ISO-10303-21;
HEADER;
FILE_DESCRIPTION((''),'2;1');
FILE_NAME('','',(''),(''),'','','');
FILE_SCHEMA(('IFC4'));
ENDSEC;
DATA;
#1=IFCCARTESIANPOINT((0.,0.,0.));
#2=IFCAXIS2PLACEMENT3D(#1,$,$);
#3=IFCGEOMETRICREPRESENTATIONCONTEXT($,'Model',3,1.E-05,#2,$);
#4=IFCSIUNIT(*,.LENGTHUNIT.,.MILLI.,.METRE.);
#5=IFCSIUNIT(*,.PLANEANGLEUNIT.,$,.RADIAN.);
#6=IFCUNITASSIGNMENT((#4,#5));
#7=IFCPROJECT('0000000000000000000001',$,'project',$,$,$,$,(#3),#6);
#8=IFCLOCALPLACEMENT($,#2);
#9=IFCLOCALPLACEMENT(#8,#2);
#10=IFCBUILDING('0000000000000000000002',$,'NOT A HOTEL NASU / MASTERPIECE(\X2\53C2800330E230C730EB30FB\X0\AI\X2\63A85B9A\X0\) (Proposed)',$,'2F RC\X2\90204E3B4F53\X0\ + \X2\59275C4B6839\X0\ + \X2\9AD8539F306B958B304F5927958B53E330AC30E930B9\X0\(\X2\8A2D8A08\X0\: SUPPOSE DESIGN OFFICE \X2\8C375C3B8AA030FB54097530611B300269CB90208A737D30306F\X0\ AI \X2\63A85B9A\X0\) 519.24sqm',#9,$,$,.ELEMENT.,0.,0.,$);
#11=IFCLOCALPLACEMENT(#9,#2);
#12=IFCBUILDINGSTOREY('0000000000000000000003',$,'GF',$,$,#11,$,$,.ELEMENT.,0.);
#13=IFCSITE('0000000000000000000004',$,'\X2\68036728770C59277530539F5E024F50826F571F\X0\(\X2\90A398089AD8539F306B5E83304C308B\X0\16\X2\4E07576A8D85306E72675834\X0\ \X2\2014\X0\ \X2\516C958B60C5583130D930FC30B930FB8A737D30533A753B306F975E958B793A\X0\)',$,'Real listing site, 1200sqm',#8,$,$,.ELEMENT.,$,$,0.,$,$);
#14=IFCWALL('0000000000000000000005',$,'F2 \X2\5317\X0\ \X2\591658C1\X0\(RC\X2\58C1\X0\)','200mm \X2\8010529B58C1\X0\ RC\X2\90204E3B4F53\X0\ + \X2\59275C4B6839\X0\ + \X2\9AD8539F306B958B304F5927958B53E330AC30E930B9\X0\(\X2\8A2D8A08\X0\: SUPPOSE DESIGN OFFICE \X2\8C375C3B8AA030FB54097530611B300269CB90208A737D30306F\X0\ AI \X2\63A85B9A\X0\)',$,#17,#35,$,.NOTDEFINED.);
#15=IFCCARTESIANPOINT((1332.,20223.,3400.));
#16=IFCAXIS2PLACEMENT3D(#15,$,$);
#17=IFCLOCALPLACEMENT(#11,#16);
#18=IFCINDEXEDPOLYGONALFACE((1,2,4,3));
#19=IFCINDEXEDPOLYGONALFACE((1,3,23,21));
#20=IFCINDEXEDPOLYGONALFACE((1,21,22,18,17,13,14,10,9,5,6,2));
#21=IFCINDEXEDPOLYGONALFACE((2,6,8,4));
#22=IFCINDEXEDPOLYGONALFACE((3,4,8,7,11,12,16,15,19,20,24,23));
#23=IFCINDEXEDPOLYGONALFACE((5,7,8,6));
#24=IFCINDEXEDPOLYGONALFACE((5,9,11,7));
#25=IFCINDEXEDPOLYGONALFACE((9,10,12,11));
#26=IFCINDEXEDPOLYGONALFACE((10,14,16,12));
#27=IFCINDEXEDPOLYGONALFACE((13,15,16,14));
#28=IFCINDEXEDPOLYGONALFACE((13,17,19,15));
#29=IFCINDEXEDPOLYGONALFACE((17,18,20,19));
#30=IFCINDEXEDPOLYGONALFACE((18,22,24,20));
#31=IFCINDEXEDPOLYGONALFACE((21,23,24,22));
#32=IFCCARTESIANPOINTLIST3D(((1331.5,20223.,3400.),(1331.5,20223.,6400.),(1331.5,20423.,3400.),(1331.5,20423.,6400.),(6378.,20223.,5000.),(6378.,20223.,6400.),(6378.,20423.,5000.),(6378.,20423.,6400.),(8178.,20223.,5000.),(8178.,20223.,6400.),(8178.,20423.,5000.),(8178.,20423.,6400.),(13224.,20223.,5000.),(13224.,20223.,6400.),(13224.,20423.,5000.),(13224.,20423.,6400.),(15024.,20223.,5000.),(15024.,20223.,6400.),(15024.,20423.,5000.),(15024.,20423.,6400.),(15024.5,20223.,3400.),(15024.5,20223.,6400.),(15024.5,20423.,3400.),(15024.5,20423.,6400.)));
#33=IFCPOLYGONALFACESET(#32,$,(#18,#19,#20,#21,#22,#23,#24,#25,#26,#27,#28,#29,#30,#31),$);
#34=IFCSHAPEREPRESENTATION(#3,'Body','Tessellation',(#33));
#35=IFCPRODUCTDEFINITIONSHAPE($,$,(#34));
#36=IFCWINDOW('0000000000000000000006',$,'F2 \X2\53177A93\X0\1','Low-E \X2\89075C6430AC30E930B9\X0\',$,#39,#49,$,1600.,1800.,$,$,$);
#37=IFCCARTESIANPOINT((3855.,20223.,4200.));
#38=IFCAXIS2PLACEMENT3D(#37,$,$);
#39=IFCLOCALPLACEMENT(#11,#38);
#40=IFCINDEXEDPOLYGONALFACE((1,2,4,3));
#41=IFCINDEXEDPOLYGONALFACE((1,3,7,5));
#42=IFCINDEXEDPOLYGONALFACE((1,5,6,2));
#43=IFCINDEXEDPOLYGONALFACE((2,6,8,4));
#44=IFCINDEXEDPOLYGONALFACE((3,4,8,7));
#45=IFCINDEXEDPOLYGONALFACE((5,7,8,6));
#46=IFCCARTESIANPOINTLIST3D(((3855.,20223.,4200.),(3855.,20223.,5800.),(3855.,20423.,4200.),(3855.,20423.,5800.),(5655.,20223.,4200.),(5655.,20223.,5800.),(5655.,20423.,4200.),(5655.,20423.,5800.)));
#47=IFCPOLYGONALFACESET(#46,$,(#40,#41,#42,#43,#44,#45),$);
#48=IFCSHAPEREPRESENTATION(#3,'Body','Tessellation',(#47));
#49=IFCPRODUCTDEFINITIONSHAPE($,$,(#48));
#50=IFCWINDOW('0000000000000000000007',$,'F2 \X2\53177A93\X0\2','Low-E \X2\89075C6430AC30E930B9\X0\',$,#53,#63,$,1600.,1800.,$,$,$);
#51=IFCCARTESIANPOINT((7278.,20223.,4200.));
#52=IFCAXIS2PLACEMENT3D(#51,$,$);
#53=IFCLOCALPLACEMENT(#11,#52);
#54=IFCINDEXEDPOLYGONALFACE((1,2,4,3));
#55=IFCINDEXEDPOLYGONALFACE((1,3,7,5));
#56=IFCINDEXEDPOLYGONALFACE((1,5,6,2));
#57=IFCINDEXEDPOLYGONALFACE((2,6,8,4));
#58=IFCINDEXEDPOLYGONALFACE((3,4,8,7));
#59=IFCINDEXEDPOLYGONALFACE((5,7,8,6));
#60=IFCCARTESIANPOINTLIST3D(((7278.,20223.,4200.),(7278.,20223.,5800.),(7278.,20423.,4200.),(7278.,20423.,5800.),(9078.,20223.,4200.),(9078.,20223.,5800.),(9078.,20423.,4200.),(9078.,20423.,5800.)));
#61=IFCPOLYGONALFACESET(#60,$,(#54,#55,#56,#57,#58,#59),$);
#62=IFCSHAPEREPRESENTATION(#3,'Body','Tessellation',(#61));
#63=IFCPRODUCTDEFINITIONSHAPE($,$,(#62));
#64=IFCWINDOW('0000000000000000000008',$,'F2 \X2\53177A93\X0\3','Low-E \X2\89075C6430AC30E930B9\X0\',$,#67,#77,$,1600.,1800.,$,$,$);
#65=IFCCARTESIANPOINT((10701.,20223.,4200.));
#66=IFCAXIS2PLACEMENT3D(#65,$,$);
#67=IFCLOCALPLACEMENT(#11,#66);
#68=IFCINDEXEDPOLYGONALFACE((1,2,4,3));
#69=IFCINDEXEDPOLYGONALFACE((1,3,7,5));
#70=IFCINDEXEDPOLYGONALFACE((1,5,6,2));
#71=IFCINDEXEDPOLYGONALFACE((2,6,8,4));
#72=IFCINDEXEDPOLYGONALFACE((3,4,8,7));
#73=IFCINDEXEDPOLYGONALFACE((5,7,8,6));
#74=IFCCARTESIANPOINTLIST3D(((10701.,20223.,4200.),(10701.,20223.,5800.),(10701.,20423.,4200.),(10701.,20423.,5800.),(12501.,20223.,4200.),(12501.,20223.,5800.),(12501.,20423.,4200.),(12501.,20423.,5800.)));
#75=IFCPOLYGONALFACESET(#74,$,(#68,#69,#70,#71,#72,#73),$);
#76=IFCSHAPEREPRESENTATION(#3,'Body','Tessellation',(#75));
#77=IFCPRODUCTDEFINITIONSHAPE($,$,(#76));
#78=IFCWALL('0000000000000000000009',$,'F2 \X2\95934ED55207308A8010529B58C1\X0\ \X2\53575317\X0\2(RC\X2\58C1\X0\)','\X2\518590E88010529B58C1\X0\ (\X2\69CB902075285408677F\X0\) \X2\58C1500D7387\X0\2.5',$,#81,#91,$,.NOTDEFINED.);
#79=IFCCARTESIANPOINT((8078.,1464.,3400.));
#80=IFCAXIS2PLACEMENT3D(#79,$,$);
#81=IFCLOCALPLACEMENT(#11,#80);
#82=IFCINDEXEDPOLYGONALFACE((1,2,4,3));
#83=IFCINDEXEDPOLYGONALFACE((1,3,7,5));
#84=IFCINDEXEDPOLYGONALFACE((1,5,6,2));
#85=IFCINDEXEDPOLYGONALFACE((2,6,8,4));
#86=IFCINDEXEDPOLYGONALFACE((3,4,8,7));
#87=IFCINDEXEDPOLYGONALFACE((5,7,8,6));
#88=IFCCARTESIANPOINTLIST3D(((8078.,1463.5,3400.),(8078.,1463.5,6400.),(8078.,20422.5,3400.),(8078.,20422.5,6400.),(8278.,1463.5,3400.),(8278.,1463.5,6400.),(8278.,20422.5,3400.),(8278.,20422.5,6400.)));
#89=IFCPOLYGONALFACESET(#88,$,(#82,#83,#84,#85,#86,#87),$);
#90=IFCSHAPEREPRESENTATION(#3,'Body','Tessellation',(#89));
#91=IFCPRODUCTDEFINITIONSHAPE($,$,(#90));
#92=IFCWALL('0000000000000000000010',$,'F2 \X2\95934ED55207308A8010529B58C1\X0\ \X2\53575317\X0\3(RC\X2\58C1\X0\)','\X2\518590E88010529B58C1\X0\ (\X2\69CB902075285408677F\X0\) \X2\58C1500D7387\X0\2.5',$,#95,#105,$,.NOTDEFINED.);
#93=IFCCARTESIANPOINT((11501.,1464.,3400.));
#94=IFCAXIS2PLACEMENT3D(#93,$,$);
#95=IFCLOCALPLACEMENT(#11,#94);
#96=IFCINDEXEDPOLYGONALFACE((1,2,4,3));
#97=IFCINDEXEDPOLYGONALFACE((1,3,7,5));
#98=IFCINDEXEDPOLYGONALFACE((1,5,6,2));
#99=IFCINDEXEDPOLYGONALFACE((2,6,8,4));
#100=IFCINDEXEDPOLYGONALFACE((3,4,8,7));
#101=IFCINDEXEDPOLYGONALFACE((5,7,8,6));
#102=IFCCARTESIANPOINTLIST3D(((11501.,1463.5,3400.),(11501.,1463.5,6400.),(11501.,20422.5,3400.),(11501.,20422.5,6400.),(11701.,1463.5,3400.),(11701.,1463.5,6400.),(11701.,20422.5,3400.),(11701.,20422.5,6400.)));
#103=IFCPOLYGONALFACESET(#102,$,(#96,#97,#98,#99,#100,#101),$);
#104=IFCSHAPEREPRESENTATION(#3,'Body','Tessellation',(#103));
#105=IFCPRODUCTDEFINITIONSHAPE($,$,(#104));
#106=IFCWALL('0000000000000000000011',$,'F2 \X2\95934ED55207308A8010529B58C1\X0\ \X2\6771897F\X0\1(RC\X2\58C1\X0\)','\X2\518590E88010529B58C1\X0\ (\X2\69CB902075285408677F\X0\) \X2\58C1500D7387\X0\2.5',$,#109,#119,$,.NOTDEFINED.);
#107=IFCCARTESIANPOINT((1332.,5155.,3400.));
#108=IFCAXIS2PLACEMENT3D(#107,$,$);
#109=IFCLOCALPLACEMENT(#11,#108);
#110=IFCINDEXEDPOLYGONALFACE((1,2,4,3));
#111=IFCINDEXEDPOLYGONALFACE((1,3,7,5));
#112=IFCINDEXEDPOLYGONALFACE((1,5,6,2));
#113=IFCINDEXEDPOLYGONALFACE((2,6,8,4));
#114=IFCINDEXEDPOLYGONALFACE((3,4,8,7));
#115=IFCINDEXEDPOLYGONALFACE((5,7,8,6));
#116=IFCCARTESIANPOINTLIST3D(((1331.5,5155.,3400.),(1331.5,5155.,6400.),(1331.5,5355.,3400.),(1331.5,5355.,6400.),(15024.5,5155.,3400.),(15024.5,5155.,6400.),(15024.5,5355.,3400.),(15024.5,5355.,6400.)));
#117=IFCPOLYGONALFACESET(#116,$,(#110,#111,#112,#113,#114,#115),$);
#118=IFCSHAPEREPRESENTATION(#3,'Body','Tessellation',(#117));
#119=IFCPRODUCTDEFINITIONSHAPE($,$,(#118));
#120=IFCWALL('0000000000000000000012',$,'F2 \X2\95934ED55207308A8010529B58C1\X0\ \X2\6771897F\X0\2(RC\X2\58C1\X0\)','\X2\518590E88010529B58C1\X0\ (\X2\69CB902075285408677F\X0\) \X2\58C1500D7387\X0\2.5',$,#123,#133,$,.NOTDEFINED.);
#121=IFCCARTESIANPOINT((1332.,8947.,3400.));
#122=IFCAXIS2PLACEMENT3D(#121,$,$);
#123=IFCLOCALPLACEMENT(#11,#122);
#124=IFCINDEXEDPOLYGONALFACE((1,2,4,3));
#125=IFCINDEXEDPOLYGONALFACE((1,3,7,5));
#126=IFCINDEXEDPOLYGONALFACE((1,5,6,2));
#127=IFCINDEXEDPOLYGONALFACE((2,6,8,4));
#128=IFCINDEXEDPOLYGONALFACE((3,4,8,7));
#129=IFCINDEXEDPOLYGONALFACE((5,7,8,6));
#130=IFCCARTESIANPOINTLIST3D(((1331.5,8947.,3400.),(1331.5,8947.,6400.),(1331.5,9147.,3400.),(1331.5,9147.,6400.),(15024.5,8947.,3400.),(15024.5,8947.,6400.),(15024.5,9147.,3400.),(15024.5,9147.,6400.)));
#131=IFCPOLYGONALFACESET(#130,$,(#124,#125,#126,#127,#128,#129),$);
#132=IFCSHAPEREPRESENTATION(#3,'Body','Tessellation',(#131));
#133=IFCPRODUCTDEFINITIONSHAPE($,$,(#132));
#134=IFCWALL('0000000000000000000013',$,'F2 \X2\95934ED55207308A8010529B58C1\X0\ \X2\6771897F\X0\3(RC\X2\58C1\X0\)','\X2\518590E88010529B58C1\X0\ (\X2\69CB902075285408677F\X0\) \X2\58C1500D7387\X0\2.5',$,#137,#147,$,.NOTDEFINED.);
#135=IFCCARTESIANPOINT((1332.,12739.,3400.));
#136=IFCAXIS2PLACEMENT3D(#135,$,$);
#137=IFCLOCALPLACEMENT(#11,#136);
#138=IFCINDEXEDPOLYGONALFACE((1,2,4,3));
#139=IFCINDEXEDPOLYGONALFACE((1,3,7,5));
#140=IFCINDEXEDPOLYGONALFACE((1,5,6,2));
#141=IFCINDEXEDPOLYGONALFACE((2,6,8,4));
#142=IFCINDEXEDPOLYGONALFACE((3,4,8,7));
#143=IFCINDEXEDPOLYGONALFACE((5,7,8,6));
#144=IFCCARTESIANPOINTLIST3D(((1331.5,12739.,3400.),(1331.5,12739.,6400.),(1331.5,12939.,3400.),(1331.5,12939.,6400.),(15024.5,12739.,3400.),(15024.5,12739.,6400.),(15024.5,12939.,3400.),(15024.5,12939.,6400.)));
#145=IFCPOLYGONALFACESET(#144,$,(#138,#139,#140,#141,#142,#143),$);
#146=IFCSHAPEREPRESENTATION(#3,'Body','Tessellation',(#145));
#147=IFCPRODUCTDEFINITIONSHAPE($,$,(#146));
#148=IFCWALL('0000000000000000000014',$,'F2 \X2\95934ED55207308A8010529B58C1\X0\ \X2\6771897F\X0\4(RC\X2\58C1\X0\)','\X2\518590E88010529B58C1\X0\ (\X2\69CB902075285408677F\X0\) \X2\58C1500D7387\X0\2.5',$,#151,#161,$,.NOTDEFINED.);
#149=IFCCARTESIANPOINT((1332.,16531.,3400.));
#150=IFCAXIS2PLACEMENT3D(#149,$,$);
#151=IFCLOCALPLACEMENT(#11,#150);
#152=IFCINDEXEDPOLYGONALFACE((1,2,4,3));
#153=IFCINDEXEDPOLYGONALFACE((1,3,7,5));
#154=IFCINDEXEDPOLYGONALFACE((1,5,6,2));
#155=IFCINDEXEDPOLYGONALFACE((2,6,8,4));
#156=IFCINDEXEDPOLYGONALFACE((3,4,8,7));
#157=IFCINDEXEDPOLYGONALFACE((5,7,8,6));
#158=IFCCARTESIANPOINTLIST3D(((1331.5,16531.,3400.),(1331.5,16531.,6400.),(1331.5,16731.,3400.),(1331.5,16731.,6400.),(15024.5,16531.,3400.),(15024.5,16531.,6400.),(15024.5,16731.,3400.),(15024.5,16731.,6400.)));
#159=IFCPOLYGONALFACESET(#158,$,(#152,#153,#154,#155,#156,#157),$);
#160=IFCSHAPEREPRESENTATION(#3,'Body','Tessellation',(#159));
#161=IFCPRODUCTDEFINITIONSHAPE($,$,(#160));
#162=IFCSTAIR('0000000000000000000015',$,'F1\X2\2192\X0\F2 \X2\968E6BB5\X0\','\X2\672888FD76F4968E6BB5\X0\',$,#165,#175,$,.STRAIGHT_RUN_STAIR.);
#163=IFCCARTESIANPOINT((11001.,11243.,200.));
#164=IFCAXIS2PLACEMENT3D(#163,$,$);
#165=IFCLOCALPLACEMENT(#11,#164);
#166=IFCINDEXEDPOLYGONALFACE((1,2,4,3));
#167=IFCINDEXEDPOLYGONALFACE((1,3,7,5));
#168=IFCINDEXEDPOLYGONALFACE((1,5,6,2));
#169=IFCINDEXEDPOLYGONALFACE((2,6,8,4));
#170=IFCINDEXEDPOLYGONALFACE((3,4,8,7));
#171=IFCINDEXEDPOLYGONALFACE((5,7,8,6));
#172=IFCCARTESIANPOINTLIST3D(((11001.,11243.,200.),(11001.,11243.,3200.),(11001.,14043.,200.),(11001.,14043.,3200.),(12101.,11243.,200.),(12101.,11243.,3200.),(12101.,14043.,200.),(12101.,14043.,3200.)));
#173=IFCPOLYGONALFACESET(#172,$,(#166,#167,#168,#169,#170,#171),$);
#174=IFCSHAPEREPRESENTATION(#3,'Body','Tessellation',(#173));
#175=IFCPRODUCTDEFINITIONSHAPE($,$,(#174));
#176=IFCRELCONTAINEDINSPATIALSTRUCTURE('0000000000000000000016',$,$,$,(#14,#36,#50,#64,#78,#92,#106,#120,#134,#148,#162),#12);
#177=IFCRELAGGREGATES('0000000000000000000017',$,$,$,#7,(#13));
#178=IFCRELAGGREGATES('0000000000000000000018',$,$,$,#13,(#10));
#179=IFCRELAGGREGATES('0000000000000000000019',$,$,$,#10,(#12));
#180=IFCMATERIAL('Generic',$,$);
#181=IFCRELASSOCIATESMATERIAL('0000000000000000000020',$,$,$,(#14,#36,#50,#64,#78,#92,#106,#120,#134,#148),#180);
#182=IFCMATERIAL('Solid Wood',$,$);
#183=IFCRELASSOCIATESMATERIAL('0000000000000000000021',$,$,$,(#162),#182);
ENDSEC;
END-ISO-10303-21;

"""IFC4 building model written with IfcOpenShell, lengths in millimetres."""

from ifc_helpers import new_model, si_unit, frame, frame_2d, origin, place, context, project, spatial, rectangle, extrude, material, element, fill, save


model = new_model("IFC4")

# Units and contexts
model_context = context("Model", 3, precision=1e-05, world=origin())
ifc_project = project(units=[si_unit("LENGTHUNIT", "METRE", prefix="MILLI"), si_unit("PLANEANGLEUNIT", "RADIAN")], contexts=[model_context])

# Site, building, storey
site_placement = place(None, origin())
site = spatial("IfcSite", under=ifc_project, at=site_placement, Name="栃木県大田原市佐良土(那須高原に広がる16万坪超の牧場 — 公開情報ベース・詳細区画は非開示)", ObjectType="Real listing site, 1200sqm", CompositionType="ELEMENT", RefElevation=0.0)
building_placement = place(site_placement, origin())
building = spatial("IfcBuilding", under=site, at=building_placement, Name="NOT A HOTEL NASU / MASTERPIECE(参考モデル・AI推定) (Proposed)", ObjectType="2F RC造主体 + 大屋根 + 高原に開く大開口ガラス(設計: SUPPOSE DESIGN OFFICE 谷尻誠・吉田愛。構造詳細は AI 推定) 519.24sqm", CompositionType="ELEMENT", ElevationOfRefHeight=0.0, ElevationOfTerrain=0.0)
storey_placement = place(building_placement, origin())
storey = spatial("IfcBuildingStorey", under=building, at=storey_placement, Name="GF", CompositionType="ELEMENT", Elevation=0.0)

# Shared definitions
ifc_material_1 = material(Name="Generic")

# Wall, openings, windows
wall_1_placement = place(storey_placement, frame((1332.0, 20223.0, 3400.0)))
wall_1 = element("IfcWall", 1, at=wall_1_placement, inside=storey, material=ifc_material_1, Name="F2 北 外壁(RC壁)", Description="200mm 耐力壁 RC造主体 + 大屋根 + 高原に開く大開口ガラス(設計: SUPPOSE DESIGN OFFICE 谷尻誠・吉田愛。構造詳細は AI 推定)", PredefinedType="NOTDEFINED", context=model_context, shape_type="SweptSolid", body=[
    extrude(rectangle(XDim=13693.0, YDim=200.0, at=frame_2d((6846.0, 100.0))), frame((1332.0, 20223.0, 3400.0)), (0.0, 0.0, 1.0), 3000.0),
])
opening_1_placement = place(storey_placement, frame((3855.0, 20223.0, 4200.0)))
opening_1 = element("IfcOpeningElement", 2, at=opening_1_placement, cuts=wall_1, PredefinedType="NOTDEFINED", context=model_context, shape_type="SweptSolid", body=[
    extrude(rectangle(XDim=1800.0, YDim=200.0, at=frame_2d((900.0, 100.0))), frame((3855.0, 20223.0, 4200.0)), (0.0, 0.0, 1.0), 1600.0),
])
opening_2_placement = place(storey_placement, frame((7278.0, 20223.0, 4200.0)))
opening_2 = element("IfcOpeningElement", 3, at=opening_2_placement, cuts=wall_1, PredefinedType="NOTDEFINED", context=model_context, shape_type="SweptSolid", body=[
    extrude(rectangle(XDim=1800.0, YDim=200.0, at=frame_2d((900.0, 100.0))), frame((7278.0, 20223.0, 4200.0)), (0.0, 0.0, 1.0), 1600.0),
])
opening_3_placement = place(storey_placement, frame((10701.0, 20223.0, 4200.0)))
opening_3 = element("IfcOpeningElement", 4, at=opening_3_placement, cuts=wall_1, PredefinedType="NOTDEFINED", context=model_context, shape_type="SweptSolid", body=[
    extrude(rectangle(XDim=1800.0, YDim=200.0, at=frame_2d((900.0, 100.0))), frame((10701.0, 20223.0, 4200.0)), (0.0, 0.0, 1.0), 1600.0),
])
window_1_placement = place(storey_placement, frame((3855.0, 20223.0, 4200.0)))
window_1 = element("IfcWindow", 5, at=window_1_placement, inside=storey, material=ifc_material_1, Name="F2 北窓1", Description="Low-E 複層ガラス", OverallHeight=1600.0, OverallWidth=1800.0, context=model_context, shape_type="SweptSolid", body=[
    extrude(rectangle(XDim=1800.0, YDim=200.0, at=frame_2d((900.0, 100.0))), frame((3855.0, 20223.0, 4200.0)), (0.0, 0.0, 1.0), 1600.0),
])
fill(opening_1, window_1)
window_2_placement = place(storey_placement, frame((7278.0, 20223.0, 4200.0)))
window_2 = element("IfcWindow", 6, at=window_2_placement, inside=storey, material=ifc_material_1, Name="F2 北窓2", Description="Low-E 複層ガラス", OverallHeight=1600.0, OverallWidth=1800.0, context=model_context, shape_type="SweptSolid", body=[
    extrude(rectangle(XDim=1800.0, YDim=200.0, at=frame_2d((900.0, 100.0))), frame((7278.0, 20223.0, 4200.0)), (0.0, 0.0, 1.0), 1600.0),
])
fill(opening_2, window_2)
window_3_placement = place(storey_placement, frame((10701.0, 20223.0, 4200.0)))
window_3 = element("IfcWindow", 7, at=window_3_placement, inside=storey, material=ifc_material_1, Name="F2 北窓3", Description="Low-E 複層ガラス", OverallHeight=1600.0, OverallWidth=1800.0, context=model_context, shape_type="SweptSolid", body=[
    extrude(rectangle(XDim=1800.0, YDim=200.0, at=frame_2d((900.0, 100.0))), frame((10701.0, 20223.0, 4200.0)), (0.0, 0.0, 1.0), 1600.0),
])
fill(opening_3, window_3)

# Walls
wall_2_placement = place(storey_placement, frame((8078.0, 1464.0, 3400.0)))
element("IfcWall", 8, at=wall_2_placement, inside=storey, material=ifc_material_1, Name="F2 間仕切り耐力壁 南北2(RC壁)", Description="内部耐力壁 (構造用合板) 壁倍率2.5", PredefinedType="NOTDEFINED", context=model_context, shape_type="SweptSolid", body=[
    extrude(rectangle(XDim=200.0, YDim=18959.0, at=frame_2d((100.0, 9479.0))), frame((8078.0, 1464.0, 3400.0)), (0.0, 0.0, 1.0), 3000.0),
])
wall_3_placement = place(storey_placement, frame((11501.0, 1464.0, 3400.0)))
element("IfcWall", 9, at=wall_3_placement, inside=storey, material=ifc_material_1, Name="F2 間仕切り耐力壁 南北3(RC壁)", Description="内部耐力壁 (構造用合板) 壁倍率2.5", PredefinedType="NOTDEFINED", context=model_context, shape_type="SweptSolid", body=[
    extrude(rectangle(XDim=200.0, YDim=18959.0, at=frame_2d((100.0, 9479.0))), frame((11501.0, 1464.0, 3400.0)), (0.0, 0.0, 1.0), 3000.0),
])
wall_4_placement = place(storey_placement, frame((1332.0, 5155.0, 3400.0)))
element("IfcWall", 10, at=wall_4_placement, inside=storey, material=ifc_material_1, Name="F2 間仕切り耐力壁 東西1(RC壁)", Description="内部耐力壁 (構造用合板) 壁倍率2.5", PredefinedType="NOTDEFINED", context=model_context, shape_type="SweptSolid", body=[
    extrude(rectangle(XDim=13693.0, YDim=200.0, at=frame_2d((6846.0, 100.0))), frame((1332.0, 5155.0, 3400.0)), (0.0, 0.0, 1.0), 3000.0),
])
wall_5_placement = place(storey_placement, frame((1332.0, 8947.0, 3400.0)))
element("IfcWall", 11, at=wall_5_placement, inside=storey, material=ifc_material_1, Name="F2 間仕切り耐力壁 東西2(RC壁)", Description="内部耐力壁 (構造用合板) 壁倍率2.5", PredefinedType="NOTDEFINED", context=model_context, shape_type="SweptSolid", body=[
    extrude(rectangle(XDim=13693.0, YDim=200.0, at=frame_2d((6846.0, 100.0))), frame((1332.0, 8947.0, 3400.0)), (0.0, 0.0, 1.0), 3000.0),
])
wall_6_placement = place(storey_placement, frame((1332.0, 12739.0, 3400.0)))
element("IfcWall", 12, at=wall_6_placement, inside=storey, material=ifc_material_1, Name="F2 間仕切り耐力壁 東西3(RC壁)", Description="内部耐力壁 (構造用合板) 壁倍率2.5", PredefinedType="NOTDEFINED", context=model_context, shape_type="SweptSolid", body=[
    extrude(rectangle(XDim=13693.0, YDim=200.0, at=frame_2d((6846.0, 100.0))), frame((1332.0, 12739.0, 3400.0)), (0.0, 0.0, 1.0), 3000.0),
])
wall_7_placement = place(storey_placement, frame((1332.0, 16531.0, 3400.0)))
element("IfcWall", 13, at=wall_7_placement, inside=storey, material=ifc_material_1, Name="F2 間仕切り耐力壁 東西4(RC壁)", Description="内部耐力壁 (構造用合板) 壁倍率2.5", PredefinedType="NOTDEFINED", context=model_context, shape_type="SweptSolid", body=[
    extrude(rectangle(XDim=13693.0, YDim=200.0, at=frame_2d((6846.0, 100.0))), frame((1332.0, 16531.0, 3400.0)), (0.0, 0.0, 1.0), 3000.0),
])

# Stair
ifc_material_2 = material(Name="Solid Wood")
stair_placement = place(storey_placement, frame((11001.0, 11243.0, 200.0)))
element("IfcStair", 14, at=stair_placement, inside=storey, material=ifc_material_2, Name="F1→F2 階段", Description="木製直階段", PredefinedType="STRAIGHT_RUN_STAIR", context=model_context, shape_type="SweptSolid", body=[
    extrude(rectangle(XDim=1100.0, YDim=2800.0, at=frame_2d((550.0, 1400.0))), frame((11001.0, 11243.0, 200.0)), (0.0, 0.0, 1.0), 3000.0),
])

save(model, "model.ifc")
